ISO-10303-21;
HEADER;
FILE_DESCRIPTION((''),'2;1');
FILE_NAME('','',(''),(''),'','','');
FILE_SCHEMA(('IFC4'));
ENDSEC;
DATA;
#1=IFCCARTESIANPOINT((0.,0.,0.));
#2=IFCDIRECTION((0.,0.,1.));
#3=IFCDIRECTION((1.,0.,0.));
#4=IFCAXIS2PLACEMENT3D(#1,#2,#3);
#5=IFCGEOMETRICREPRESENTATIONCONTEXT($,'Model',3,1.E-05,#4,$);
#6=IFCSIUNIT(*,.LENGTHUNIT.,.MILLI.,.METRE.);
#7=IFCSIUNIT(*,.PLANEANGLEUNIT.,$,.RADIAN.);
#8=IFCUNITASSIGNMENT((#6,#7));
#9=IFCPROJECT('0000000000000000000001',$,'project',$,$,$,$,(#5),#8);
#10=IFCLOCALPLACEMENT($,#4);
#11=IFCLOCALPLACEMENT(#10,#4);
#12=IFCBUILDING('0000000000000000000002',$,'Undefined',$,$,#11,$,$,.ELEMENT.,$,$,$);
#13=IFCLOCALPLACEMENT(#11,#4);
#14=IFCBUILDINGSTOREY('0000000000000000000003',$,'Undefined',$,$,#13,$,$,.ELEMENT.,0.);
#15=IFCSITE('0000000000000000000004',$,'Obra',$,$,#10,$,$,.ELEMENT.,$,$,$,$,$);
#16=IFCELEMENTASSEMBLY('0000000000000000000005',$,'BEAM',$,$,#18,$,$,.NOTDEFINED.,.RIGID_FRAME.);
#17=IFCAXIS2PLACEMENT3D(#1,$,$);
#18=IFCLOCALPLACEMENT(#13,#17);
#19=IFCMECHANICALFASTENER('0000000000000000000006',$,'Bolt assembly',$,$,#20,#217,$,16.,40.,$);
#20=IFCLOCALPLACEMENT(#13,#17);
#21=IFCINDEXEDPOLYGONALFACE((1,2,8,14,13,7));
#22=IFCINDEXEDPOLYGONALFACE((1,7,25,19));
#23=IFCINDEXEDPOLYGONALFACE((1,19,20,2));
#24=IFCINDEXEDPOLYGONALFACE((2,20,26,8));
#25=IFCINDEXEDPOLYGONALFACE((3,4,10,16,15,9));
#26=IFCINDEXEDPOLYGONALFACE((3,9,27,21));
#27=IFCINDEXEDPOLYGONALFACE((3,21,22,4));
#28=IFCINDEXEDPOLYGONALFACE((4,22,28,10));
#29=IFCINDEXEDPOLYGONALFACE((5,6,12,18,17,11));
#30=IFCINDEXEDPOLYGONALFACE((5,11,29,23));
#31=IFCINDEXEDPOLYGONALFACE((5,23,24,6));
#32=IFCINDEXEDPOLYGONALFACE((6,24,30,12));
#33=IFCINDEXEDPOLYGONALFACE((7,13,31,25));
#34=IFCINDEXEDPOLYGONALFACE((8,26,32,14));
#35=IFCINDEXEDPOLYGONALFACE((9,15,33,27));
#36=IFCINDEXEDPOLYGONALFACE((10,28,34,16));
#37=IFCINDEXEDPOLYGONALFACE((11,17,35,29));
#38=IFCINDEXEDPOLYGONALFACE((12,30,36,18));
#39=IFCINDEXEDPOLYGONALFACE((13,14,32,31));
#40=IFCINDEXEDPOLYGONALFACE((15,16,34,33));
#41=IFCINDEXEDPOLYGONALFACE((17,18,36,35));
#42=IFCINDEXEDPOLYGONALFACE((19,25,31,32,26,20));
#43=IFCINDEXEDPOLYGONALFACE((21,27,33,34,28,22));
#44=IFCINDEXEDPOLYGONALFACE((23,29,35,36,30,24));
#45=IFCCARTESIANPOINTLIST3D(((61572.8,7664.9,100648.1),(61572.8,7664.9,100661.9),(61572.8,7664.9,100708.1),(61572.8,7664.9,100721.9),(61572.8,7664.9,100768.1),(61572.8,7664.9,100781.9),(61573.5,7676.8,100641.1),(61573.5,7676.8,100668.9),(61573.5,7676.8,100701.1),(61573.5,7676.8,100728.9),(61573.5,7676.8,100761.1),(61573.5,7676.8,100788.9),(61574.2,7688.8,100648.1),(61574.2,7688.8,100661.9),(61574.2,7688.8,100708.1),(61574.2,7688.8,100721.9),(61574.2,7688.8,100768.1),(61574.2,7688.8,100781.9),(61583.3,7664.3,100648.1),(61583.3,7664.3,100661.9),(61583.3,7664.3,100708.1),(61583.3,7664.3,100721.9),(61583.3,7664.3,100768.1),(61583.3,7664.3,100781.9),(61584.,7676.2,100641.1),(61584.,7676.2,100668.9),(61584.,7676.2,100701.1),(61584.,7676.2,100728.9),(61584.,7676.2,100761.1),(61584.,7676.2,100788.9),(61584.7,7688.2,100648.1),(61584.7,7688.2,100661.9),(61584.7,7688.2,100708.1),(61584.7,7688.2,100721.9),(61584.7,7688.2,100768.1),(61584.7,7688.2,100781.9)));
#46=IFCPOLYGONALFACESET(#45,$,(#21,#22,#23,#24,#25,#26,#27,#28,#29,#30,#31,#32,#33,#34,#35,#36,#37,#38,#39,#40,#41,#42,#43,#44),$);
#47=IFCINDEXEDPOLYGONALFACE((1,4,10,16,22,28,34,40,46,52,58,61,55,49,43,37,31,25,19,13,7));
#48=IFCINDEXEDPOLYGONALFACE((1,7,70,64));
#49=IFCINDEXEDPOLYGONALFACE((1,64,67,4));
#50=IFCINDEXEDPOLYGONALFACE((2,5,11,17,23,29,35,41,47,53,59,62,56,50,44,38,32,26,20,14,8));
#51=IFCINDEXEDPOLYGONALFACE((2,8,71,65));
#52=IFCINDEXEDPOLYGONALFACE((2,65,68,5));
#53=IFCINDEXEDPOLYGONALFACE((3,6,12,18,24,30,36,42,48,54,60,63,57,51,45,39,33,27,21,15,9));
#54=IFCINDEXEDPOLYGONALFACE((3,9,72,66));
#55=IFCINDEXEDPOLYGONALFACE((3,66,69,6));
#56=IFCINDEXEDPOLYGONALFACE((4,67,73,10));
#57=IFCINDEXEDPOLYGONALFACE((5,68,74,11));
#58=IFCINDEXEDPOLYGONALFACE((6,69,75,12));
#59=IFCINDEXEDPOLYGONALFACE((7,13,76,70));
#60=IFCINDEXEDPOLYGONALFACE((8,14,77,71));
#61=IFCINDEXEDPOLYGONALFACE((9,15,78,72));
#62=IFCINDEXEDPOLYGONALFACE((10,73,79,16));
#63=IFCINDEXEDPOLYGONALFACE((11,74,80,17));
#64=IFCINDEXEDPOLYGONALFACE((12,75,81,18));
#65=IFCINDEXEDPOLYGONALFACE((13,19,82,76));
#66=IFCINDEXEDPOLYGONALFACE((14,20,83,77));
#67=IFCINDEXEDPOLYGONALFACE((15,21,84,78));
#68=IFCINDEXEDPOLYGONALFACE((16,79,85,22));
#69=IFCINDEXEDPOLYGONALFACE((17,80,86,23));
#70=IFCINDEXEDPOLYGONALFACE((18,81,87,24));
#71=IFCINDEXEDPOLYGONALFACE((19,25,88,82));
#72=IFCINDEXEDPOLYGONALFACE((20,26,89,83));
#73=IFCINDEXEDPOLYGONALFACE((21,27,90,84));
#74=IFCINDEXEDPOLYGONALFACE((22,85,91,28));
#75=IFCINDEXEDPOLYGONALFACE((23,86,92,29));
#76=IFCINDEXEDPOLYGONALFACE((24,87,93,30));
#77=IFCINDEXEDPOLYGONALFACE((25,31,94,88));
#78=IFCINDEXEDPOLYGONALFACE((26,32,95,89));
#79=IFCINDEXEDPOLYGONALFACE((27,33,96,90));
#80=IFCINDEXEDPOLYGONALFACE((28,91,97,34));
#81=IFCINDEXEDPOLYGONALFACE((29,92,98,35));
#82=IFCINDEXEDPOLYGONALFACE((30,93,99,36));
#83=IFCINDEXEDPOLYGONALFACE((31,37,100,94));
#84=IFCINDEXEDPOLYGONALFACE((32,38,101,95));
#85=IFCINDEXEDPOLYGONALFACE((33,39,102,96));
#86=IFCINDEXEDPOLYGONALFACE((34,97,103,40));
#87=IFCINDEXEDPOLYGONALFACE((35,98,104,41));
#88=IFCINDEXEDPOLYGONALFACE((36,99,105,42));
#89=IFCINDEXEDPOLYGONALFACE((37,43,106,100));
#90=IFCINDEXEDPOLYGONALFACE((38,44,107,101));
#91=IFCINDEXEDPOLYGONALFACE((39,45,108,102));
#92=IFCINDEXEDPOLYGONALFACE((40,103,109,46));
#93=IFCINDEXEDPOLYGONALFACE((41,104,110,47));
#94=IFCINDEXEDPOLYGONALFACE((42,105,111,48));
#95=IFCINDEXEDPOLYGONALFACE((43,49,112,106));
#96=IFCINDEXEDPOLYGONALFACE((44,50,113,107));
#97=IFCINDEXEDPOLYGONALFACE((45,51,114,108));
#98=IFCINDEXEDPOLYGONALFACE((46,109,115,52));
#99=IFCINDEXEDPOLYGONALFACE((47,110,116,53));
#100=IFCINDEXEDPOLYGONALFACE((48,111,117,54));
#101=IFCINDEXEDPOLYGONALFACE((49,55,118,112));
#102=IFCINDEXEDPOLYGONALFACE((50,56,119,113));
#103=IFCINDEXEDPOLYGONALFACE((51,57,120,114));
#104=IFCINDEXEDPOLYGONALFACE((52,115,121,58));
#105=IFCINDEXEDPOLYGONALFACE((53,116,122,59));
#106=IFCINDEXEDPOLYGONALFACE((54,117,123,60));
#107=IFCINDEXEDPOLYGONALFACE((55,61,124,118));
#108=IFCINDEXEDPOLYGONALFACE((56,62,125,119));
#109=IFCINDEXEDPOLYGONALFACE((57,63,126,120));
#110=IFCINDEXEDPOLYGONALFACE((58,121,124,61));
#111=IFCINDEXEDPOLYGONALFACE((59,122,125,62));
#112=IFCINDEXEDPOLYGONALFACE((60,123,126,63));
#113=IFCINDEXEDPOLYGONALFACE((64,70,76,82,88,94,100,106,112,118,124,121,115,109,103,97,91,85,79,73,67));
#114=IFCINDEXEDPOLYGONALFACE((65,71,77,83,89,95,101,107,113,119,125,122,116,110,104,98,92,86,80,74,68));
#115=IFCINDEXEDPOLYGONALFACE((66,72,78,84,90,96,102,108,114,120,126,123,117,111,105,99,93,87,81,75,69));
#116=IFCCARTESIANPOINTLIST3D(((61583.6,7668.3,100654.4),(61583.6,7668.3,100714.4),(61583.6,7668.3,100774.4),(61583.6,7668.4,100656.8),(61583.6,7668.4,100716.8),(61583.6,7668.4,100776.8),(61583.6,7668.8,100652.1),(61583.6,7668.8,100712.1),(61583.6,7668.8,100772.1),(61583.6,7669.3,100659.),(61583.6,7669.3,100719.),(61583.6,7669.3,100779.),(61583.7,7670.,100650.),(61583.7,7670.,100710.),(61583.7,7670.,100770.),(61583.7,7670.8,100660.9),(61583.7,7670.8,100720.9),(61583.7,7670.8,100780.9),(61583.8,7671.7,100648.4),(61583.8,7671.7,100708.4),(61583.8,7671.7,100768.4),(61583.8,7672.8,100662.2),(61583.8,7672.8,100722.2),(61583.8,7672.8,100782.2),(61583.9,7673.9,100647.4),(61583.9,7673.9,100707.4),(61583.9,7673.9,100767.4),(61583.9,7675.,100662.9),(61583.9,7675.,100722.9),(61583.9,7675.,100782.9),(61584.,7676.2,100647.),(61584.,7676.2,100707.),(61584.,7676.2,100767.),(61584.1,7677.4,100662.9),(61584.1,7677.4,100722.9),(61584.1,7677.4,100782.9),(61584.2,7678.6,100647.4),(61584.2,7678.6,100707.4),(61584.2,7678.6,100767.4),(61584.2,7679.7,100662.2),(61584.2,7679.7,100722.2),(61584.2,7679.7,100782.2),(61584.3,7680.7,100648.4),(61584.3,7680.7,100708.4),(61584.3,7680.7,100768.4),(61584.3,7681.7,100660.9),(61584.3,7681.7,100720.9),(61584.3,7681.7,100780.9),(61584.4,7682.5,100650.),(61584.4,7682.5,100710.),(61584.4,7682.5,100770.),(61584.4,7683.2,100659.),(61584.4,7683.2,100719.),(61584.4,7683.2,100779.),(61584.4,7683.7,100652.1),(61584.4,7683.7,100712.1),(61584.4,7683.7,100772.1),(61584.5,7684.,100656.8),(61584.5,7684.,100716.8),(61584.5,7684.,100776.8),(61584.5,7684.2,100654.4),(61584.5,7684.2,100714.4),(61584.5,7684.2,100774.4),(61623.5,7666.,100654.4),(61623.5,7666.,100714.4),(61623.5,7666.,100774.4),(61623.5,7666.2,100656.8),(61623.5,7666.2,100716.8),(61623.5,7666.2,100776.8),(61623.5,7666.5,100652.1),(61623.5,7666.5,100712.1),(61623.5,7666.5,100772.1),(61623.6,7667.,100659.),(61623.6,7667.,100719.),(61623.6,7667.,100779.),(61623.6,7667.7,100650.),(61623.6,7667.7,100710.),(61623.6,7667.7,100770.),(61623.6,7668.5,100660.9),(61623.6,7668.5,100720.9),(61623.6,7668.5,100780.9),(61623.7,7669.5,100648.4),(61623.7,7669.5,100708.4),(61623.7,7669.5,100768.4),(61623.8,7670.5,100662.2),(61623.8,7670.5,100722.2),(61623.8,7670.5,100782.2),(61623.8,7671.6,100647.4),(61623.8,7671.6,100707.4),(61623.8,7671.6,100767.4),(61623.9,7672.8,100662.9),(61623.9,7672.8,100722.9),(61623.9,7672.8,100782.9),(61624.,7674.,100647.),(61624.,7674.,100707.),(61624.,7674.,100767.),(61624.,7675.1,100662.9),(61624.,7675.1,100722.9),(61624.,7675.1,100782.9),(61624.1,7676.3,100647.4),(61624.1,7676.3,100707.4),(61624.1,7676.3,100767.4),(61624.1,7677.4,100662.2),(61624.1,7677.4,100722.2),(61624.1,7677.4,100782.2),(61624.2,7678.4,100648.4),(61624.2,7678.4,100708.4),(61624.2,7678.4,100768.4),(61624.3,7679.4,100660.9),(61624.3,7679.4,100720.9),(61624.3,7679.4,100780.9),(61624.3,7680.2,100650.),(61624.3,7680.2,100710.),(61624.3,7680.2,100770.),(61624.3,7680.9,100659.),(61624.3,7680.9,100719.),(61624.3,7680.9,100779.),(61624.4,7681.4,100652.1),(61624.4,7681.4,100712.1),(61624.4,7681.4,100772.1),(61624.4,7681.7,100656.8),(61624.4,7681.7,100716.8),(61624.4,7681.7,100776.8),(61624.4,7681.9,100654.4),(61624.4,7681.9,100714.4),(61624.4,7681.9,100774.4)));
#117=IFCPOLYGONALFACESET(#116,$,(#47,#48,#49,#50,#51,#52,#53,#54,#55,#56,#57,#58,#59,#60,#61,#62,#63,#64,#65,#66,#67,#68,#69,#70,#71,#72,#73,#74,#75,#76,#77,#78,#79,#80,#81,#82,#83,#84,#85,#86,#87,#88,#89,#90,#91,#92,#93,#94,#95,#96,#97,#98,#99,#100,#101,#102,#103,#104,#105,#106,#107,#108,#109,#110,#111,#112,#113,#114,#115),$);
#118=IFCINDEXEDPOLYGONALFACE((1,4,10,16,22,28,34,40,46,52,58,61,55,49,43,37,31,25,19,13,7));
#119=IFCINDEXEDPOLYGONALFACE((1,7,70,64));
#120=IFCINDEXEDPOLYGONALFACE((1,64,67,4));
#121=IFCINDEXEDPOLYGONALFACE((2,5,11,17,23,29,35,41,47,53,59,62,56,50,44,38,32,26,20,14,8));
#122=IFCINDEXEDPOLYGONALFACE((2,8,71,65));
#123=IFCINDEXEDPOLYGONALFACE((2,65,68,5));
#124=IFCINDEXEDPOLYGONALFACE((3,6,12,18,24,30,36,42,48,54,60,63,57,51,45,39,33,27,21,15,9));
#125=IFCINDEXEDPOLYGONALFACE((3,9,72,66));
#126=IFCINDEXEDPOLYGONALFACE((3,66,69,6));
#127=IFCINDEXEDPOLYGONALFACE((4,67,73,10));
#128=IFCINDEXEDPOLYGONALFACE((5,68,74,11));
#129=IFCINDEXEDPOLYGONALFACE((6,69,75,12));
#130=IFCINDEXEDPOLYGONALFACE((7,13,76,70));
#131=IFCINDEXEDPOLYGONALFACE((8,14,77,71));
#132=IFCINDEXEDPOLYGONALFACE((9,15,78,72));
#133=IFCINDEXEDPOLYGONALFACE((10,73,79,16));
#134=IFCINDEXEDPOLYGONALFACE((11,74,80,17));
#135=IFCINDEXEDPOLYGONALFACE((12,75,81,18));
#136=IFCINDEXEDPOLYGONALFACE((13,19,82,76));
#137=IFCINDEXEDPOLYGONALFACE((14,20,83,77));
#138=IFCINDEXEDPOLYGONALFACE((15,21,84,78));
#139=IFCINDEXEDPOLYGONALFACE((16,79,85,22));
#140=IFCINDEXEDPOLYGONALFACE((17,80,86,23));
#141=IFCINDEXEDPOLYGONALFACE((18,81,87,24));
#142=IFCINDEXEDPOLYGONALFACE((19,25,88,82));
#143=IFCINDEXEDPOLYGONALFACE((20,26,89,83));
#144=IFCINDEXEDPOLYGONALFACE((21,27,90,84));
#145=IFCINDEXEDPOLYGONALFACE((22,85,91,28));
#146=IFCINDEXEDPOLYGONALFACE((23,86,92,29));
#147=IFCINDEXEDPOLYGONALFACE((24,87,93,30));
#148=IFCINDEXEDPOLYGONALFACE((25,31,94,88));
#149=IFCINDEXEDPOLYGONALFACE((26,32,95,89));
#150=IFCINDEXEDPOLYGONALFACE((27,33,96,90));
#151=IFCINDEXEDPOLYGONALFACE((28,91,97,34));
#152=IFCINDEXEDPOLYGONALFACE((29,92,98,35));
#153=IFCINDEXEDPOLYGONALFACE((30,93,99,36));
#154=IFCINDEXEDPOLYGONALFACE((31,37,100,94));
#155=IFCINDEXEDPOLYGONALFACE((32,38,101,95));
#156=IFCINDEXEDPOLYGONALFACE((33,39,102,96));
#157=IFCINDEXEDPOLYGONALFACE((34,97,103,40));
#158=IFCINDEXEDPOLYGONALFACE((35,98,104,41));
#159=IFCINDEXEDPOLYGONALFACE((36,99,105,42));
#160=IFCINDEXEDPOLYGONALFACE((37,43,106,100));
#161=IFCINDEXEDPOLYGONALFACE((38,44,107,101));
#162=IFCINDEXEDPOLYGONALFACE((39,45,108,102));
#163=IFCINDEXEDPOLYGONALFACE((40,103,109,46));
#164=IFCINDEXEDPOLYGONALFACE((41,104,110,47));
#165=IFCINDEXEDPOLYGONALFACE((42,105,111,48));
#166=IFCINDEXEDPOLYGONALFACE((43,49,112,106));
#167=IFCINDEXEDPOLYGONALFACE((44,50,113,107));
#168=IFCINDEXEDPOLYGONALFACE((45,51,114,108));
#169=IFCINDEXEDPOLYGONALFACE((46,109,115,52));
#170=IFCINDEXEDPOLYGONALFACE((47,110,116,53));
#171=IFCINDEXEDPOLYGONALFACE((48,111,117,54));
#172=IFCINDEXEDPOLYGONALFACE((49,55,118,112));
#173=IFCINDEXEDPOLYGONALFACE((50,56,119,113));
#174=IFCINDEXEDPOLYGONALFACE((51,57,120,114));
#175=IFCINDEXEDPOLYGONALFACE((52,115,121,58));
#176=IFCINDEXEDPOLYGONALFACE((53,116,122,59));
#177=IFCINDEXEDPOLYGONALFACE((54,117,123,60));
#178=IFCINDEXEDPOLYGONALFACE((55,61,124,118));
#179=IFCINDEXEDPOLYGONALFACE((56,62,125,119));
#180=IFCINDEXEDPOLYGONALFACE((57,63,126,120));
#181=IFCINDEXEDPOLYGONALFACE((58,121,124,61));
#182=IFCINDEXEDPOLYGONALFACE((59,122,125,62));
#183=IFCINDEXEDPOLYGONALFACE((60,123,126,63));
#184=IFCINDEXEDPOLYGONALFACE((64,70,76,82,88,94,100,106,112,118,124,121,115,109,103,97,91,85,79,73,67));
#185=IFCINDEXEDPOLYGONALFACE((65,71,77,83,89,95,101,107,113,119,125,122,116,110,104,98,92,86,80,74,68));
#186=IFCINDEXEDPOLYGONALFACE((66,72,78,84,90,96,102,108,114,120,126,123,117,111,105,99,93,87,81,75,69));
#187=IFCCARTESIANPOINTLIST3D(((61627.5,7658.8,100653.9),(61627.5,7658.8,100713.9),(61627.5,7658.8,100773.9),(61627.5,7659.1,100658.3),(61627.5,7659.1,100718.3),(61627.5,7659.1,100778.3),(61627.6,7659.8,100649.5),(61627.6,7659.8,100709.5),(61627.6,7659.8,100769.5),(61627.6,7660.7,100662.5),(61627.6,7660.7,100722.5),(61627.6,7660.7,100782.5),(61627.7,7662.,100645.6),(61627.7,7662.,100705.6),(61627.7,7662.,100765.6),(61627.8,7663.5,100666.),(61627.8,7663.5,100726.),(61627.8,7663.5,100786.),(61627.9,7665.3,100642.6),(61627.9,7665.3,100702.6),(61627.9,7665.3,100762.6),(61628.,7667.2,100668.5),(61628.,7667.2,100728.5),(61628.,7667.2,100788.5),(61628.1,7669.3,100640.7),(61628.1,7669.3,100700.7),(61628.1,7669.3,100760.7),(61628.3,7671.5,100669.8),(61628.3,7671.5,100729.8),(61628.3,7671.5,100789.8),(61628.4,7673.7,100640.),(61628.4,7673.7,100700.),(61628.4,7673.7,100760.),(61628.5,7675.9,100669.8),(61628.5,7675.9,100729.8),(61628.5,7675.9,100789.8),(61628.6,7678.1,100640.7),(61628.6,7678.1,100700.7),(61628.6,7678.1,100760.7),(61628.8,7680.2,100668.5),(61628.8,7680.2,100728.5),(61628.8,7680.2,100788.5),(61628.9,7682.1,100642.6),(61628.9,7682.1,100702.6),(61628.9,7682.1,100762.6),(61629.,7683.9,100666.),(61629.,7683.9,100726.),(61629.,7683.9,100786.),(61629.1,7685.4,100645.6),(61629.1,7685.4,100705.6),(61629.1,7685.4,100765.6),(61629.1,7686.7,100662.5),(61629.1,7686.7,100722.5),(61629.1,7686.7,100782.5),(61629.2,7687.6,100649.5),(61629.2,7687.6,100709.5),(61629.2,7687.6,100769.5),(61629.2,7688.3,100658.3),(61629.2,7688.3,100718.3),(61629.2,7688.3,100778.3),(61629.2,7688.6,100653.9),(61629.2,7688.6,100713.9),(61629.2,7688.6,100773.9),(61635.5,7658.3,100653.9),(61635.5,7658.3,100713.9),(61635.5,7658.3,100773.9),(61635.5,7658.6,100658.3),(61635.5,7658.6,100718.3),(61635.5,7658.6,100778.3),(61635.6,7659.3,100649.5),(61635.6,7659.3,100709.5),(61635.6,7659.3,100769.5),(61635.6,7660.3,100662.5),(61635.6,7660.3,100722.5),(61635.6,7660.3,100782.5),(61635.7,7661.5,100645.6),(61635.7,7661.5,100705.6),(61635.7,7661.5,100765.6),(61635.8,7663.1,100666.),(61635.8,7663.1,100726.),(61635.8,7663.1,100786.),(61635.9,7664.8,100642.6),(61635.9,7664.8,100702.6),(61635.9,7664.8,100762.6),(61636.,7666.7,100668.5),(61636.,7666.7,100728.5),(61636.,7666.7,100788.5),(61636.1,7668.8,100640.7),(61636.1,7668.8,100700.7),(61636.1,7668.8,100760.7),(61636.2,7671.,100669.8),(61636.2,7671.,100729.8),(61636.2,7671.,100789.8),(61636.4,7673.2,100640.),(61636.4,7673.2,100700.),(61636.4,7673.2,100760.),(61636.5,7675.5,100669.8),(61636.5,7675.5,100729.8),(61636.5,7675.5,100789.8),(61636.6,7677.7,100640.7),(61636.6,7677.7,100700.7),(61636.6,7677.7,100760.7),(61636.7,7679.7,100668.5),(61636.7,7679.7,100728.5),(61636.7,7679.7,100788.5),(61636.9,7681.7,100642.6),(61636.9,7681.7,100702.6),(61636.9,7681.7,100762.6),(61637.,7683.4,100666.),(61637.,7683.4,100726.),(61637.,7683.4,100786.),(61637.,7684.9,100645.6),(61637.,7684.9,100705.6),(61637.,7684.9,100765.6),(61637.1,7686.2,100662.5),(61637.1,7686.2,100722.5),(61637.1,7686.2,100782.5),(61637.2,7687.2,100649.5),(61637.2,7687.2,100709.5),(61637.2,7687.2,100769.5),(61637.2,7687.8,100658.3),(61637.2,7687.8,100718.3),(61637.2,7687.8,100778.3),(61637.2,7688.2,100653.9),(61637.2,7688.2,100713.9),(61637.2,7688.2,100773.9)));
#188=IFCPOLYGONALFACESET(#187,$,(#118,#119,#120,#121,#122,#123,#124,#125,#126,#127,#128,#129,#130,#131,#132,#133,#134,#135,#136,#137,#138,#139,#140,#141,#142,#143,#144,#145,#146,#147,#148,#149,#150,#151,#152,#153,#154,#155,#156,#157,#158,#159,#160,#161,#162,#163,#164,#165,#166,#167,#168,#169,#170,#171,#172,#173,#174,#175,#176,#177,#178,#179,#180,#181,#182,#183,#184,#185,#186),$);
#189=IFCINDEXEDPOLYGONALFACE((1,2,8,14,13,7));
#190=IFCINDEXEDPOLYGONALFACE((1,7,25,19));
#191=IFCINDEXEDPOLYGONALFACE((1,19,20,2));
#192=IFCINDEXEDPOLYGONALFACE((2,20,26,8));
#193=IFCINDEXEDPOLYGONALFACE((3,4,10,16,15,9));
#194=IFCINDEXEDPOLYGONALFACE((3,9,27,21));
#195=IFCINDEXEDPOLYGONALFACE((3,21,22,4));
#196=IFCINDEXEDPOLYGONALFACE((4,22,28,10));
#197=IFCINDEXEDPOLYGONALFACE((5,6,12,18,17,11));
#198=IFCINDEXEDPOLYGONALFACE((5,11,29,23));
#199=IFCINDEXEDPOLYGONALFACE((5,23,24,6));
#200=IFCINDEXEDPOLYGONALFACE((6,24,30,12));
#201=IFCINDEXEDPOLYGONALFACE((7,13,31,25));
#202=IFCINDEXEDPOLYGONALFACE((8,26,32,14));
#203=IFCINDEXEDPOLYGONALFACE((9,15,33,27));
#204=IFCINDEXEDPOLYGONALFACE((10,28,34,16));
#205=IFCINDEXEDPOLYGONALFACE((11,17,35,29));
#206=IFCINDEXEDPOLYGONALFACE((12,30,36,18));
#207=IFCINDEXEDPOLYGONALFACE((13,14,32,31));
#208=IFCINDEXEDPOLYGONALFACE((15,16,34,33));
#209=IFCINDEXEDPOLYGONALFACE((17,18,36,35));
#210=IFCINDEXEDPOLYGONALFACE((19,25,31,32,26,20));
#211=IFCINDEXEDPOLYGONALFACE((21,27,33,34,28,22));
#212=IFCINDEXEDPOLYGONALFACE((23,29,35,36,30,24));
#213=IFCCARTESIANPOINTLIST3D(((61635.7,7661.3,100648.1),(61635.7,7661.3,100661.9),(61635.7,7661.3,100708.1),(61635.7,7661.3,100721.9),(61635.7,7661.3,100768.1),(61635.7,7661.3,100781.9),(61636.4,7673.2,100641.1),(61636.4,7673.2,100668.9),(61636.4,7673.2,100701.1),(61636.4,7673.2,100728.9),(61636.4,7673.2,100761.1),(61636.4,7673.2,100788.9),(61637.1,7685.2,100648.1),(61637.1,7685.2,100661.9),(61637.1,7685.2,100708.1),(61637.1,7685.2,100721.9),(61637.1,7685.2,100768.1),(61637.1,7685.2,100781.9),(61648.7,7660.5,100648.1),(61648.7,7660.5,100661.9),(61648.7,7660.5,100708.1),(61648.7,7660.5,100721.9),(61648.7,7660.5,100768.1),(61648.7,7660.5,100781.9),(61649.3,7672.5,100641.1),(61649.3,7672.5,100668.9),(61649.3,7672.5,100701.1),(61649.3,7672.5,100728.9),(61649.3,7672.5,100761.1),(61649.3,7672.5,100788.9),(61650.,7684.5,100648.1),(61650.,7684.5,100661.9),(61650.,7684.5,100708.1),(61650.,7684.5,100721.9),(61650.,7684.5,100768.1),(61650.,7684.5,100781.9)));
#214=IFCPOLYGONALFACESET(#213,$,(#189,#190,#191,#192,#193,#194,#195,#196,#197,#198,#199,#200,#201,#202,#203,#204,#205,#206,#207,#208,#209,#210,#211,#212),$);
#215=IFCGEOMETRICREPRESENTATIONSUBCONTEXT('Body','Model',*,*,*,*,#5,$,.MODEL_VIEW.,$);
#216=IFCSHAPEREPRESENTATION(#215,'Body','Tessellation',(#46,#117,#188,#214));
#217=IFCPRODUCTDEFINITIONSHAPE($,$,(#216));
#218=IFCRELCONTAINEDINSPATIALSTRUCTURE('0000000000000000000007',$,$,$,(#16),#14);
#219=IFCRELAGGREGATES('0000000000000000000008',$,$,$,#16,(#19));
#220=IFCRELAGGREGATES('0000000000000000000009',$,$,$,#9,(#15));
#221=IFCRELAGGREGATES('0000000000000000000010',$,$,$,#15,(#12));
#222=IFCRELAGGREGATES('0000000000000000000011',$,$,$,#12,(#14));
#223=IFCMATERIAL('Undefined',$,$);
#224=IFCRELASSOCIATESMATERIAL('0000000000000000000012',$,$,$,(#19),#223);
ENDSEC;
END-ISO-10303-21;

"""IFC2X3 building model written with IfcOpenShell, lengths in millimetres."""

from ifc_helpers import new_model, si_unit, frame, origin_with_axes, origin_2d_with_axis, place, context, subcontext, project, spatial, polyline, circle, outline, extrude, source, transform, mapped, material, element, aggregate, save


model = new_model("IFC2X3")

# Units and contexts
model_context = context("Model", 3, precision=1e-05, world=origin_with_axes())
body_context = subcontext(model_context, "Body", "Model", "MODEL_VIEW")
ifc_project = project(units=[si_unit("LENGTHUNIT", "METRE", prefix="MILLI"), si_unit("PLANEANGLEUNIT", "RADIAN")], contexts=[model_context])

# Site, building, storey
site_placement = place(None, origin_with_axes())
site = spatial("IfcSite", under=ifc_project, at=site_placement, Name="Obra", CompositionType="ELEMENT")
building_placement = place(site_placement, origin_with_axes())
building = spatial("IfcBuilding", under=site, at=building_placement, Name="Undefined", CompositionType="ELEMENT")
storey_placement = place(building_placement, origin_with_axes())
storey = spatial("IfcBuildingStorey", under=building, at=storey_placement, Name="Undefined", CompositionType="ELEMENT", Elevation=0.0)

# Shared definitions
ifc_material_1 = material(Name="Undefined")

# Element assembly
assembly_1_placement = place(storey_placement, origin_with_axes())
assembly_1 = element("IfcElementAssembly", 1, at=assembly_1_placement, inside=storey, Name="BEAM", AssemblyPlace="NOTDEFINED", PredefinedType="RIGID_FRAME")

# Shared definitions
shared_shape_1 = source(origin_with_axes(), body_context, "Body", "SweptSolid", [
    extrude(outline(polyline([(13.9, 0.0), (6.9, 12.0), (-6.9, 12.0), (-13.9, 0.0), (-6.9, -12.0), (6.9, -12.0), (13.9, 0.0)])), frame((0.0, -19.7, 0.0), z_axis=(0.0, 1.0, 0.0), x_axis=(1.0, 0.0, 0.0)), (0.0, 0.0, 1.0), 10.6),
    extrude(circle(Radius=8.0, at=origin_2d_with_axis()), frame((0.0, -9.1, 0.0), z_axis=(0.0, 1.0, 0.0), x_axis=(1.0, 0.0, 0.0)), (0.0, 0.0, 1.0), 40.0),
    extrude(circle(Radius=15.0, at=origin_2d_with_axis()), frame((0.0, 35.3, 0.0), z_axis=(0.0, 1.0, 0.0), x_axis=(1.0, 0.0, 0.0)), (0.0, 0.0, 1.0), 8.0),
    extrude(outline(polyline([(13.9, 0.0), (6.9, 12.0), (-6.9, 12.0), (-13.9, 0.0), (-6.9, -12.0), (6.9, -12.0), (13.9, 0.0)])), frame((0.0, 43.3, 0.0), z_axis=(0.0, 1.0, 0.0), x_axis=(1.0, 0.0, 0.0)), (0.0, 0.0, 1.0), 13.0),
])

# Mechanical fastener
mechanical_fastener_1_placement = place(assembly_1_placement, frame((61596.0, 7725.6, 100835.0), z_axis=(-0.05711, -0.998368, 0.0), x_axis=(0.0, 0.0, -1.0)))
mechanical_fastener_1 = element("IfcMechanicalFastener", 2, at=mechanical_fastener_1_placement, material=ifc_material_1, Name="Bolt assembly", NominalDiameter=16.0, NominalLength=40.0, context=body_context, shape_type="MappedRepresentation", body=[
    mapped(shared_shape_1, transform((60.0, 0.0, 50.0))),
    mapped(shared_shape_1, transform((120.0, 0.0, 50.0))),
    mapped(shared_shape_1, transform((180.0, 0.0, 50.0))),
])
aggregate(assembly_1, [mechanical_fastener_1])

save(model, "model.ifc")
